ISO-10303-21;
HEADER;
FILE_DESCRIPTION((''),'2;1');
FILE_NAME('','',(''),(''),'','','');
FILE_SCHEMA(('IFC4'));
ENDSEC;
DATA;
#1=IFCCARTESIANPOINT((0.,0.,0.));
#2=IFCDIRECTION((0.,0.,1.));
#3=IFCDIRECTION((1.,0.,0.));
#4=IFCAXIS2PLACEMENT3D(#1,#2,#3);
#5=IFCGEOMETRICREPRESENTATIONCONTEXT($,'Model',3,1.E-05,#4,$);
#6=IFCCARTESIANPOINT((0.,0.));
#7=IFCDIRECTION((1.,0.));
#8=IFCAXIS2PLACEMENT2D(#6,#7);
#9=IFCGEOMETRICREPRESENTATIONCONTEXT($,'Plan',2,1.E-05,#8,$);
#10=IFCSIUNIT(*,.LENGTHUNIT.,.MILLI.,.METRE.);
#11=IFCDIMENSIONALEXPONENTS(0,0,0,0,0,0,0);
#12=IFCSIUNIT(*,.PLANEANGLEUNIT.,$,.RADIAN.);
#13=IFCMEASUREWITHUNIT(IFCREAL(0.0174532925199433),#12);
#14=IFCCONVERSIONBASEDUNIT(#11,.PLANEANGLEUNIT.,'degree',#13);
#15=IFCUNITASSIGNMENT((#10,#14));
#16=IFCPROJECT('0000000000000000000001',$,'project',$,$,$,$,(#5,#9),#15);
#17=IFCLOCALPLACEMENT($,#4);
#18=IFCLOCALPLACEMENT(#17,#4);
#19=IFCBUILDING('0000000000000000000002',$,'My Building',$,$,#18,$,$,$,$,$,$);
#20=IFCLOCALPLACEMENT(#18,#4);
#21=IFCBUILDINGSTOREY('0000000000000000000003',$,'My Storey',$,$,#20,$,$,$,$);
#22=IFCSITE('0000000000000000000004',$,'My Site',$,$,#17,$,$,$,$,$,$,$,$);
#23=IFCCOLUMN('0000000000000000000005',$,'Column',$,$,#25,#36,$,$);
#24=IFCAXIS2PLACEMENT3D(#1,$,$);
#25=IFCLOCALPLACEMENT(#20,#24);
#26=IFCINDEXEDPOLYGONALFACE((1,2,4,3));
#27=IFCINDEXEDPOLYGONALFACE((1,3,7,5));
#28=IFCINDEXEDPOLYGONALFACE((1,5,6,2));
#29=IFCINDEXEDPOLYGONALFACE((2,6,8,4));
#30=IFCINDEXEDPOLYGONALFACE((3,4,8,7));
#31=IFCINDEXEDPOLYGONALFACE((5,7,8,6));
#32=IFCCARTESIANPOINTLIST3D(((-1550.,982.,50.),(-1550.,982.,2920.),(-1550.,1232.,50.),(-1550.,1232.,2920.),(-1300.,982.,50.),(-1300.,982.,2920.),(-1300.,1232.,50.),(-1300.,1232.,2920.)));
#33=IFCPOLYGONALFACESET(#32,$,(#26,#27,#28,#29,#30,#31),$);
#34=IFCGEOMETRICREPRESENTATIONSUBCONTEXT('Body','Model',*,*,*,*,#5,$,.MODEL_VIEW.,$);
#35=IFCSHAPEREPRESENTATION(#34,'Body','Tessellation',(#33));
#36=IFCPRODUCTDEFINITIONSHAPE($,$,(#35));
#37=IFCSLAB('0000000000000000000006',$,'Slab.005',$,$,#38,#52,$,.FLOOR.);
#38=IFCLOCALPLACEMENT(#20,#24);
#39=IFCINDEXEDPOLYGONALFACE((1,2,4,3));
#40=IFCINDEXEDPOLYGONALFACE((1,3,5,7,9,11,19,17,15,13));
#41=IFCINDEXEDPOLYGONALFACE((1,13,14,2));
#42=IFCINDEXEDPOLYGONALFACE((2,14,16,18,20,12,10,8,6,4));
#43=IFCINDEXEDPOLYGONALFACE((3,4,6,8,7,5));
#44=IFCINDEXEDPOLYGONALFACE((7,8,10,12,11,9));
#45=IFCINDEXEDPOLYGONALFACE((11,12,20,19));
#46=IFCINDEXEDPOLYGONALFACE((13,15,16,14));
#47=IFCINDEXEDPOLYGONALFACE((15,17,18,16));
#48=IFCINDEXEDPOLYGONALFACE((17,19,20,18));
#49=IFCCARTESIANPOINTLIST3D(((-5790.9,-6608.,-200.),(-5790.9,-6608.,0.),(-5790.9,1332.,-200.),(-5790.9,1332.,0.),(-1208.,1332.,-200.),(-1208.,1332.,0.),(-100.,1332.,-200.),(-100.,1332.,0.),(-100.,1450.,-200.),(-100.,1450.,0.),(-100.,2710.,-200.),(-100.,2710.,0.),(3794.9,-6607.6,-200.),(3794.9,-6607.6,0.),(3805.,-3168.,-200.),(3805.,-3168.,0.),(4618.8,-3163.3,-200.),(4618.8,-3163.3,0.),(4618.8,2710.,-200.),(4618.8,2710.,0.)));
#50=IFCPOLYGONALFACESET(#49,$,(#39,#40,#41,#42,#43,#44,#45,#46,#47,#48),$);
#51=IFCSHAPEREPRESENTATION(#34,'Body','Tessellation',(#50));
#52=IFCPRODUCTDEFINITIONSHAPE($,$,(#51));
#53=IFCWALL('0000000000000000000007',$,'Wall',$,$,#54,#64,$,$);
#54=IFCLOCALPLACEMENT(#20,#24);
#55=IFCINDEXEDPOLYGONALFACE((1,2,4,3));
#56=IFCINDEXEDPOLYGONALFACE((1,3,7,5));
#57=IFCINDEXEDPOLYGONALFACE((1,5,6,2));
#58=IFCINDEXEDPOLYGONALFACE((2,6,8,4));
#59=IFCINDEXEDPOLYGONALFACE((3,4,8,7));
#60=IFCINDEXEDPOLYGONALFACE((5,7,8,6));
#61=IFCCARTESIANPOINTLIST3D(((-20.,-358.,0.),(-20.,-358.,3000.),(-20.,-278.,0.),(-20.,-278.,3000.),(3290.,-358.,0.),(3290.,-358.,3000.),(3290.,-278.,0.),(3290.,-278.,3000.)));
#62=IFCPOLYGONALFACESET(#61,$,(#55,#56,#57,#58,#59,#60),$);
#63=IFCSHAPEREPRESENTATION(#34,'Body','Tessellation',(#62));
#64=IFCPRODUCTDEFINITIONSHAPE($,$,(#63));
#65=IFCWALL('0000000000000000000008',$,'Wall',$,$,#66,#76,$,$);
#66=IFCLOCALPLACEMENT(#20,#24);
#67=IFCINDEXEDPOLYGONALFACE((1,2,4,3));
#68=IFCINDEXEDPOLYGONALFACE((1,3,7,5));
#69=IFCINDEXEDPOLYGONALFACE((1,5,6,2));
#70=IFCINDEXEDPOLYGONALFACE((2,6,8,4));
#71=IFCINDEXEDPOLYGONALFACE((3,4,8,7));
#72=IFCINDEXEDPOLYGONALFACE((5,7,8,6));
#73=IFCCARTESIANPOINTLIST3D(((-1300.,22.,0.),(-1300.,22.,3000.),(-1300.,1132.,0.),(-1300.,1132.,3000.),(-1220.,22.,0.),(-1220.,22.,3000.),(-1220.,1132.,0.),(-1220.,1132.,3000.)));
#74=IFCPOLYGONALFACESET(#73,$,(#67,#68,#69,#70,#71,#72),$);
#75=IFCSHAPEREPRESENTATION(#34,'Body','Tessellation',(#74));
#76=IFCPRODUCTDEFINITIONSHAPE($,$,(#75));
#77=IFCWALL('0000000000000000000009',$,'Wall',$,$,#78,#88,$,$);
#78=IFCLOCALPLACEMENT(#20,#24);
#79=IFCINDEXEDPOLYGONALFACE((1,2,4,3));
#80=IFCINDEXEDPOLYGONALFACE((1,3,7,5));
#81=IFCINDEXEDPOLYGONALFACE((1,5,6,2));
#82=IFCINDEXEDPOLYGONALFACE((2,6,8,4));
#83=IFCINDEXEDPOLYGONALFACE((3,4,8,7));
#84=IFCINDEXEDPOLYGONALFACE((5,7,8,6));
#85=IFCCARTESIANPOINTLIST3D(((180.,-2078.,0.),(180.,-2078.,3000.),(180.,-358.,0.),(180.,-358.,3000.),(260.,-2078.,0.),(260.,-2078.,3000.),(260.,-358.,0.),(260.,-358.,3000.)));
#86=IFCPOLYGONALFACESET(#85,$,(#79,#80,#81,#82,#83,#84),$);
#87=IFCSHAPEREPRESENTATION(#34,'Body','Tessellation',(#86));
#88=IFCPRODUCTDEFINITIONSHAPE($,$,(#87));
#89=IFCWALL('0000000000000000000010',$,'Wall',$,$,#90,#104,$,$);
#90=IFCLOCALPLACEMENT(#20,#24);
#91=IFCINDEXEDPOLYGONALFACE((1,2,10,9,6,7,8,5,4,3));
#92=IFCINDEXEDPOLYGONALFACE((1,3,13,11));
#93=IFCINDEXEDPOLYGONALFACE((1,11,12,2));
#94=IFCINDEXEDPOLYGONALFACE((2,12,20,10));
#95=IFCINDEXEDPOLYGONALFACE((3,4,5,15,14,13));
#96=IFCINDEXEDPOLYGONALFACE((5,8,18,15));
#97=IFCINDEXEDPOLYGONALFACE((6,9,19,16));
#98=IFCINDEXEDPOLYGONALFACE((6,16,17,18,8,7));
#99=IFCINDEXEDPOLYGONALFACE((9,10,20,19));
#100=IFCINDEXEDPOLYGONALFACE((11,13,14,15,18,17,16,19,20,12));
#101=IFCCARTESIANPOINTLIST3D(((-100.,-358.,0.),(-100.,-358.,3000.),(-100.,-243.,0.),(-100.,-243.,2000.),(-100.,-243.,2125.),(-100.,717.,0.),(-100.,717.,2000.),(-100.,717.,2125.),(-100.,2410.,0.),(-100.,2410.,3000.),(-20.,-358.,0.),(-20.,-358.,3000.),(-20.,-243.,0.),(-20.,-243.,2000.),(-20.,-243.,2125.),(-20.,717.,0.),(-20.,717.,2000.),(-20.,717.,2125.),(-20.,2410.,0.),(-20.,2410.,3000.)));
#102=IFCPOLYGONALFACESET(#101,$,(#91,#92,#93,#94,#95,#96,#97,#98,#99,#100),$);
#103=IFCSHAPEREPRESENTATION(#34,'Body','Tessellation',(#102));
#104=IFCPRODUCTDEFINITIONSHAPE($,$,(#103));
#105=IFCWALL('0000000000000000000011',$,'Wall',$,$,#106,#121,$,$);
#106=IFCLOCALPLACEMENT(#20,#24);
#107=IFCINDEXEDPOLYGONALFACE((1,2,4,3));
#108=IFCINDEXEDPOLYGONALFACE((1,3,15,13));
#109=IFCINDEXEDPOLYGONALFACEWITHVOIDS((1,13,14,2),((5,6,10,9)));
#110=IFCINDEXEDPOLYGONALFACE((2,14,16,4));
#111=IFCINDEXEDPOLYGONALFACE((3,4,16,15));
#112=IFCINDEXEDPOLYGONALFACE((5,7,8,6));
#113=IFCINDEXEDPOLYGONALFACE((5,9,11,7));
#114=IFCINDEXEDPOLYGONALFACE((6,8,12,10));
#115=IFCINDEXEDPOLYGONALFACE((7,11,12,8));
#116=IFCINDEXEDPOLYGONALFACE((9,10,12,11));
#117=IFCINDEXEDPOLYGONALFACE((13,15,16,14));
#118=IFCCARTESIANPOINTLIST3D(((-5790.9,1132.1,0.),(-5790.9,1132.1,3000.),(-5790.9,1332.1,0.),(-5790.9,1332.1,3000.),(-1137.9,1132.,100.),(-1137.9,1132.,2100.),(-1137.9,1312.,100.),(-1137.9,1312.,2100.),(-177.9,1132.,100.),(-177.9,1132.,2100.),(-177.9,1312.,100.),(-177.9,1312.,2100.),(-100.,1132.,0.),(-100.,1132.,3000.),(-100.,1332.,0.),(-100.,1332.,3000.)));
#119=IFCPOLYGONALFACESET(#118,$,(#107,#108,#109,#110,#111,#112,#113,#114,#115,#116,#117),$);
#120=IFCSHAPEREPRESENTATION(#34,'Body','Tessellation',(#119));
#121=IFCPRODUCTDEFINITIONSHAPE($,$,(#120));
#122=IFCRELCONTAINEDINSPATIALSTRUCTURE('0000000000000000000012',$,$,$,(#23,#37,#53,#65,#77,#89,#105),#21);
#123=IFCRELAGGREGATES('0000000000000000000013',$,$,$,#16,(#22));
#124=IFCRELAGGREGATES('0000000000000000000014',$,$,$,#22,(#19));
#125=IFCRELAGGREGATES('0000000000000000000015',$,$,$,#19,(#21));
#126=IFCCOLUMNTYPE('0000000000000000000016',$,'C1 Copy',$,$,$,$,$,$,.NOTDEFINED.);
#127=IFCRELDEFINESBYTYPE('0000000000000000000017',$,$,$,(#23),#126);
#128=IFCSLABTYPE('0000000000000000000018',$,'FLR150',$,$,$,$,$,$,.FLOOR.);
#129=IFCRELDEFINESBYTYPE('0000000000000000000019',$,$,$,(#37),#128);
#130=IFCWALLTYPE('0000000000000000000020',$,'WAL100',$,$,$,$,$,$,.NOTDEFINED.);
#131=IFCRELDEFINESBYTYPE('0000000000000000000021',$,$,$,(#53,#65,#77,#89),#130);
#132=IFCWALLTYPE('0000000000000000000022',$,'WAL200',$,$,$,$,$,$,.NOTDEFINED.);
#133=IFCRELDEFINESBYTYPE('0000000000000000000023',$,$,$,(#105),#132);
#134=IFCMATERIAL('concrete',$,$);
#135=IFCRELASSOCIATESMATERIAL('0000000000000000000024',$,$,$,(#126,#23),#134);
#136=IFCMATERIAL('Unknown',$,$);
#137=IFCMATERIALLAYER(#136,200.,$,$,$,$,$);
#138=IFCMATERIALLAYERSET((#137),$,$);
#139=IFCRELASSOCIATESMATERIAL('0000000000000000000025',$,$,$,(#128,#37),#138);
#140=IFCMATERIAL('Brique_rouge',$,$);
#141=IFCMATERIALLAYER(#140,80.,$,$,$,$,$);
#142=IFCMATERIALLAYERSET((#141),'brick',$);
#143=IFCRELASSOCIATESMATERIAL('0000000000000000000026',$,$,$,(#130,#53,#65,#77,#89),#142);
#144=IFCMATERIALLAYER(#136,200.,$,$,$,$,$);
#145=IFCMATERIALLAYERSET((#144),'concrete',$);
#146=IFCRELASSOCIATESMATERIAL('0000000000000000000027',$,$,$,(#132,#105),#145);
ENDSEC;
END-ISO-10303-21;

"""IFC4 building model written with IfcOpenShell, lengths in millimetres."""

from ifc_helpers import new_model, entity, si_unit, converted_unit, frame, origin_with_axes, origin_2d_with_axis, place, context, subcontext, project, spatial, line, indexed_curve, rectangle, outline, extrude, source, transform, mapped, material, layer, layer_set, layer_usage, material_profile, profile_set, profile_usage, type_object, element, save


model = new_model("IFC4")

# Units and contexts
model_context = context("Model", 3, precision=1e-05, world=origin_with_axes())
plan_context = context("Plan", 2, precision=1e-05, world=origin_2d_with_axis())
body_context_1 = subcontext(model_context, "Body", "Model", "MODEL_VIEW")
ifc_project = project(units=[si_unit("LENGTHUNIT", "METRE", prefix="MILLI"), converted_unit("PLANEANGLEUNIT", "degree", entity("IfcReal", 0.0174532925199433), si_unit("PLANEANGLEUNIT", "RADIAN"), dimensions=[0, 0, 0, 0, 0, 0, 0])], contexts=[model_context, plan_context])

# Site, building, storey
site_placement = place(None, origin_with_axes())
site = spatial("IfcSite", under=ifc_project, at=site_placement, Name="My Site")
building_placement = place(site_placement, origin_with_axes())
building = spatial("IfcBuilding", under=site, at=building_placement, Name="My Building")
storey_placement = place(building_placement, origin_with_axes())
storey = spatial("IfcBuildingStorey", under=building, at=storey_placement, Name="My Storey")

# Column
ifc_material_1 = material(Name="concrete")
ifc_material_profile = material_profile(ifc_material_1, rectangle(XDim=250.0, YDim=250.0))
ifc_profile_set = profile_set([ifc_material_profile], Name="concrete")
ifc_profile_usage = profile_usage(ifc_profile_set)
column_type = type_object("IfcColumnType", Name="C1 Copy", PredefinedType="NOTDEFINED", material=ifc_profile_set)
column_placement = place(storey_placement, frame((-1425.0, 1107.0, 50.0), z_axis=(0.0, 0.0, 1.0), x_axis=(1.0, 0.0, 0.0)))
element("IfcColumn", 1, at=column_placement, inside=storey, type_object=column_type, material=ifc_profile_usage, Name="Column", context=body_context_1, shape_type="SweptSolid", body=[
    extrude(rectangle(XDim=250.0, YDim=250.0), origin_with_axes(), (0.0, 0.0, 1.0), 2870.0),
])

# Slab
ifc_material_2 = material(Name="Unknown")
ifc_layer_1 = layer(ifc_material_2, 200.0)
ifc_layer_set_1 = layer_set([ifc_layer_1])
ifc_layer_usage_1 = layer_usage(ifc_layer_set_1, "AXIS3", "POSITIVE", 0.0)
slab_type = type_object("IfcSlabType", Name="FLR150", PredefinedType="FLOOR", material=ifc_layer_set_1)
slab_placement = place(storey_placement, frame((0.0, 0.0, -200.0), z_axis=(0.0, 0.0, 1.0), x_axis=(1.0, 0.0, 0.0)))
element("IfcSlab", 2, at=slab_placement, inside=storey, type_object=slab_type, material=ifc_layer_usage_1, Name="Slab.005", PredefinedType="FLOOR", context=body_context_1, shape_type="SweptSolid", body=[
    extrude(outline(indexed_curve([(-100.0, 1450.0), (-100.0, 2710.0), (4618.8, 2710.0), (3794.9, -6607.6), (-5790.9, -6608.0), (-5790.9, 1332.0), (-1208.0, 1332.0), (-100.0, 1332.0), (4618.8, -3163.3), (3805.0, -3168.0)], segments=[line(8, 7), line(7, 6), line(6, 5), line(5, 4), line(4, 10), line(10, 9), line(9, 3), line(3, 2), line(2, 1), line(1, 8)], self_intersect=False)), None, (0.0, 0.0, 1.0), 200.0),
])

# Wall
ifc_material_3 = material(Name="Brique_rouge")
ifc_layer_2 = layer(ifc_material_3, 80.0)
ifc_layer_set_2 = layer_set([ifc_layer_2], Name="brick")
ifc_layer_usage_2 = layer_usage(ifc_layer_set_2, "AXIS2", "POSITIVE", 0.0)
wall_type_1 = type_object("IfcWallType", Name="WAL100", PredefinedType="NOTDEFINED", material=ifc_layer_set_2)
wall_1_placement = place(storey_placement, frame((-20.0, -358.0, 0.0), z_axis=(0.0, 0.0, 1.0), x_axis=(1.0, 0.0, 0.0)))
element("IfcWall", 3, at=wall_1_placement, inside=storey, type_object=wall_type_1, material=ifc_layer_usage_2, Name="Wall", context=body_context_1, shape_type="SweptSolid", body=[
    extrude(outline(indexed_curve([(0.0, 0.0), (0.0, 80.0), (3310.0, 80.0), (3310.0, 0.0), (0.0, 0.0)], self_intersect=False)), origin_with_axes(), (0.0, 0.0, 1.0), 3000.0),
])

# Walls
ifc_layer_usage_3 = layer_usage(ifc_layer_set_2, "AXIS2", "POSITIVE", 0.0)
wall_2_placement = place(storey_placement, frame((-1300.0, 1132.0, 0.0), z_axis=(0.0, 0.0, 1.0), x_axis=(-0.000001, -1.0, 0.0)))
element("IfcWall", 4, at=wall_2_placement, inside=storey, type_object=wall_type_1, material=ifc_layer_usage_3, Name="Wall", context=body_context_1, shape_type="SweptSolid", body=[
    extrude(outline(indexed_curve([(0.0, 0.0), (0.0, 80.0), (1110.0, 80.0), (1110.0, 0.0), (0.0, 0.0)], self_intersect=False)), origin_with_axes(), (0.0, 0.0, 1.0), 3000.0),
])
ifc_layer_usage_4 = layer_usage(ifc_layer_set_2, "AXIS2", "POSITIVE", 0.0)
wall_3_placement = place(storey_placement, frame((180.0, -358.0, 0.0), z_axis=(0.0, 0.0, 1.0), x_axis=(-0.000001, -1.0, 0.0)))
element("IfcWall", 5, at=wall_3_placement, inside=storey, type_object=wall_type_1, material=ifc_layer_usage_4, Name="Wall", context=body_context_1, shape_type="SweptSolid", body=[
    extrude(outline(indexed_curve([(0.0, 0.0), (0.0, 80.0), (1720.0, 80.0), (1720.0, 0.0), (0.0, 0.0)], self_intersect=False)), origin_with_axes(), (0.0, 0.0, 1.0), 3000.0),
])

# Wall, openings
ifc_layer_usage_5 = layer_usage(ifc_layer_set_2, "AXIS2", "POSITIVE", 0.0)
wall_4_placement = place(storey_placement, frame((-20.0, -358.0, 0.0), z_axis=(0.0, 0.0, 1.0), x_axis=(0.000001, 1.0, 0.0)))
wall_4 = element("IfcWall", 6, at=wall_4_placement, inside=storey, type_object=wall_type_1, material=ifc_layer_usage_5, Name="Wall", context=body_context_1, shape_type="SweptSolid", body=[
    extrude(outline(indexed_curve([(0.0, 0.0), (0.0, 80.0), (2768.0, 80.0), (2768.0, 0.0), (0.0, 0.0)], self_intersect=False)), origin_with_axes(), (0.0, 0.0, 1.0), 3000.0),
])
shared_shape_1 = source(origin_with_axes(), body_context_1, "Body", "SweptSolid", [
    extrude(outline(indexed_curve([(0.0, 0.0), (960.0, 0.0), (960.0, 2000.0), (0.0, 2000.0)], segments=[line(1, 2, 3, 4, 1)])), frame((0.0, -600.0, 0.0), z_axis=(0.0, -1.0, 0.0), x_axis=(1.0, 0.0, 0.0)), (0.0, 0.0, -1.0), 1200.0),
])
opening_1_placement = place(wall_4_placement, frame((115.0, 0.0, 0.0), z_axis=(0.0, 0.0, 1.0), x_axis=(1.0, 0.0, 0.0)))
element("IfcOpeningElement", 7, at=opening_1_placement, cuts=wall_4, PredefinedType="OPENING", context=body_context_1, shape_type="MappedRepresentation", body=[
    mapped(shared_shape_1, transform((0.0, 0.0, 0.0), x_axis=(1.0, 0.0, 0.0), y_axis=(0.0, 1.0, 0.0), z_axis=(0.0, 0.0, 1.0), scale=1.0)),
])
shared_shape_2 = source(origin_with_axes(), body_context_1, "Body", "SweptSolid", [
    extrude(outline(indexed_curve([(0.0, 0.0), (960.0, 0.0), (960.0, 2125.0), (0.0, 2125.0)], segments=[line(4, 1), line(1, 2), line(2, 3), line(3, 4)], self_intersect=False)), frame((0.0, -600.0, 0.0), z_axis=(0.0, -1.0, 0.0), x_axis=(1.0, 0.0, 0.0)), (0.0, 0.0, -1.0), 1200.0),
])
opening_2_placement = place(wall_4_placement, frame((115.0, 0.0, 0.0), z_axis=(0.0, 0.0, 1.0), x_axis=(1.0, 0.0, 0.0)))
element("IfcOpeningElement", 8, at=opening_2_placement, cuts=wall_4, PredefinedType="OPENING", context=body_context_1, shape_type="MappedRepresentation", body=[
    mapped(shared_shape_2, transform((0.0, 0.0, 0.0), x_axis=(1.0, 0.0, 0.0), y_axis=(0.0, 1.0, 0.0), z_axis=(0.0, 0.0, 1.0), scale=1.0)),
])

# Wall, opening
ifc_layer_3 = layer(ifc_material_2, 200.0)
ifc_layer_set_3 = layer_set([ifc_layer_3], Name="concrete")
ifc_layer_usage_6 = layer_usage(ifc_layer_set_3, "AXIS2", "POSITIVE", 0.0)
wall_type_2 = type_object("IfcWallType", Name="WAL200", PredefinedType="NOTDEFINED", material=ifc_layer_set_3)
wall_5_placement = place(storey_placement, frame((-5790.9, 1132.1, 0.0), z_axis=(0.0, 0.0, 1.0), x_axis=(1.0, -0.000001, 0.0)))
wall_5 = element("IfcWall", 9, at=wall_5_placement, inside=storey, type_object=wall_type_2, material=ifc_layer_usage_6, Name="Wall", context=body_context_1, shape_type="SweptSolid", body=[
    extrude(outline(indexed_curve([(0.0, 0.0), (0.0, 200.0), (5690.9, 200.0), (5690.9, 0.0), (0.0, 0.0)], self_intersect=False)), origin_with_axes(), (0.0, 0.0, 1.0), 3000.0),
])
shared_shape_3 = source(origin_with_axes(), body_context_1, "Body", "SweptSolid", [
    extrude(outline(indexed_curve([(0.0, 0.0), (960.0, 0.0), (960.0, 2000.0), (0.0, 2000.0)], segments=[line(1, 2, 3, 4, 1)])), frame((0.0, -100.0, 0.0), z_axis=(0.0, -1.0, 0.0), x_axis=(1.0, 0.0, 0.0)), (0.0, 0.0, -1.0), 280.0),
])
opening_3_placement = place(wall_5_placement, frame((4653.0, 0.0, 100.0), z_axis=(0.0, 0.0, 1.0), x_axis=(1.0, 0.0, 0.0)))
element("IfcOpeningElement", 10, at=opening_3_placement, cuts=wall_5, PredefinedType="OPENING", context=body_context_1, shape_type="MappedRepresentation", body=[
    mapped(shared_shape_3, transform((0.0, 0.0, 0.0), x_axis=(1.0, 0.0, 0.0), y_axis=(0.0, 1.0, 0.0), z_axis=(0.0, 0.0, 1.0), scale=1.0)),
])

save(model, "model.ifc")
